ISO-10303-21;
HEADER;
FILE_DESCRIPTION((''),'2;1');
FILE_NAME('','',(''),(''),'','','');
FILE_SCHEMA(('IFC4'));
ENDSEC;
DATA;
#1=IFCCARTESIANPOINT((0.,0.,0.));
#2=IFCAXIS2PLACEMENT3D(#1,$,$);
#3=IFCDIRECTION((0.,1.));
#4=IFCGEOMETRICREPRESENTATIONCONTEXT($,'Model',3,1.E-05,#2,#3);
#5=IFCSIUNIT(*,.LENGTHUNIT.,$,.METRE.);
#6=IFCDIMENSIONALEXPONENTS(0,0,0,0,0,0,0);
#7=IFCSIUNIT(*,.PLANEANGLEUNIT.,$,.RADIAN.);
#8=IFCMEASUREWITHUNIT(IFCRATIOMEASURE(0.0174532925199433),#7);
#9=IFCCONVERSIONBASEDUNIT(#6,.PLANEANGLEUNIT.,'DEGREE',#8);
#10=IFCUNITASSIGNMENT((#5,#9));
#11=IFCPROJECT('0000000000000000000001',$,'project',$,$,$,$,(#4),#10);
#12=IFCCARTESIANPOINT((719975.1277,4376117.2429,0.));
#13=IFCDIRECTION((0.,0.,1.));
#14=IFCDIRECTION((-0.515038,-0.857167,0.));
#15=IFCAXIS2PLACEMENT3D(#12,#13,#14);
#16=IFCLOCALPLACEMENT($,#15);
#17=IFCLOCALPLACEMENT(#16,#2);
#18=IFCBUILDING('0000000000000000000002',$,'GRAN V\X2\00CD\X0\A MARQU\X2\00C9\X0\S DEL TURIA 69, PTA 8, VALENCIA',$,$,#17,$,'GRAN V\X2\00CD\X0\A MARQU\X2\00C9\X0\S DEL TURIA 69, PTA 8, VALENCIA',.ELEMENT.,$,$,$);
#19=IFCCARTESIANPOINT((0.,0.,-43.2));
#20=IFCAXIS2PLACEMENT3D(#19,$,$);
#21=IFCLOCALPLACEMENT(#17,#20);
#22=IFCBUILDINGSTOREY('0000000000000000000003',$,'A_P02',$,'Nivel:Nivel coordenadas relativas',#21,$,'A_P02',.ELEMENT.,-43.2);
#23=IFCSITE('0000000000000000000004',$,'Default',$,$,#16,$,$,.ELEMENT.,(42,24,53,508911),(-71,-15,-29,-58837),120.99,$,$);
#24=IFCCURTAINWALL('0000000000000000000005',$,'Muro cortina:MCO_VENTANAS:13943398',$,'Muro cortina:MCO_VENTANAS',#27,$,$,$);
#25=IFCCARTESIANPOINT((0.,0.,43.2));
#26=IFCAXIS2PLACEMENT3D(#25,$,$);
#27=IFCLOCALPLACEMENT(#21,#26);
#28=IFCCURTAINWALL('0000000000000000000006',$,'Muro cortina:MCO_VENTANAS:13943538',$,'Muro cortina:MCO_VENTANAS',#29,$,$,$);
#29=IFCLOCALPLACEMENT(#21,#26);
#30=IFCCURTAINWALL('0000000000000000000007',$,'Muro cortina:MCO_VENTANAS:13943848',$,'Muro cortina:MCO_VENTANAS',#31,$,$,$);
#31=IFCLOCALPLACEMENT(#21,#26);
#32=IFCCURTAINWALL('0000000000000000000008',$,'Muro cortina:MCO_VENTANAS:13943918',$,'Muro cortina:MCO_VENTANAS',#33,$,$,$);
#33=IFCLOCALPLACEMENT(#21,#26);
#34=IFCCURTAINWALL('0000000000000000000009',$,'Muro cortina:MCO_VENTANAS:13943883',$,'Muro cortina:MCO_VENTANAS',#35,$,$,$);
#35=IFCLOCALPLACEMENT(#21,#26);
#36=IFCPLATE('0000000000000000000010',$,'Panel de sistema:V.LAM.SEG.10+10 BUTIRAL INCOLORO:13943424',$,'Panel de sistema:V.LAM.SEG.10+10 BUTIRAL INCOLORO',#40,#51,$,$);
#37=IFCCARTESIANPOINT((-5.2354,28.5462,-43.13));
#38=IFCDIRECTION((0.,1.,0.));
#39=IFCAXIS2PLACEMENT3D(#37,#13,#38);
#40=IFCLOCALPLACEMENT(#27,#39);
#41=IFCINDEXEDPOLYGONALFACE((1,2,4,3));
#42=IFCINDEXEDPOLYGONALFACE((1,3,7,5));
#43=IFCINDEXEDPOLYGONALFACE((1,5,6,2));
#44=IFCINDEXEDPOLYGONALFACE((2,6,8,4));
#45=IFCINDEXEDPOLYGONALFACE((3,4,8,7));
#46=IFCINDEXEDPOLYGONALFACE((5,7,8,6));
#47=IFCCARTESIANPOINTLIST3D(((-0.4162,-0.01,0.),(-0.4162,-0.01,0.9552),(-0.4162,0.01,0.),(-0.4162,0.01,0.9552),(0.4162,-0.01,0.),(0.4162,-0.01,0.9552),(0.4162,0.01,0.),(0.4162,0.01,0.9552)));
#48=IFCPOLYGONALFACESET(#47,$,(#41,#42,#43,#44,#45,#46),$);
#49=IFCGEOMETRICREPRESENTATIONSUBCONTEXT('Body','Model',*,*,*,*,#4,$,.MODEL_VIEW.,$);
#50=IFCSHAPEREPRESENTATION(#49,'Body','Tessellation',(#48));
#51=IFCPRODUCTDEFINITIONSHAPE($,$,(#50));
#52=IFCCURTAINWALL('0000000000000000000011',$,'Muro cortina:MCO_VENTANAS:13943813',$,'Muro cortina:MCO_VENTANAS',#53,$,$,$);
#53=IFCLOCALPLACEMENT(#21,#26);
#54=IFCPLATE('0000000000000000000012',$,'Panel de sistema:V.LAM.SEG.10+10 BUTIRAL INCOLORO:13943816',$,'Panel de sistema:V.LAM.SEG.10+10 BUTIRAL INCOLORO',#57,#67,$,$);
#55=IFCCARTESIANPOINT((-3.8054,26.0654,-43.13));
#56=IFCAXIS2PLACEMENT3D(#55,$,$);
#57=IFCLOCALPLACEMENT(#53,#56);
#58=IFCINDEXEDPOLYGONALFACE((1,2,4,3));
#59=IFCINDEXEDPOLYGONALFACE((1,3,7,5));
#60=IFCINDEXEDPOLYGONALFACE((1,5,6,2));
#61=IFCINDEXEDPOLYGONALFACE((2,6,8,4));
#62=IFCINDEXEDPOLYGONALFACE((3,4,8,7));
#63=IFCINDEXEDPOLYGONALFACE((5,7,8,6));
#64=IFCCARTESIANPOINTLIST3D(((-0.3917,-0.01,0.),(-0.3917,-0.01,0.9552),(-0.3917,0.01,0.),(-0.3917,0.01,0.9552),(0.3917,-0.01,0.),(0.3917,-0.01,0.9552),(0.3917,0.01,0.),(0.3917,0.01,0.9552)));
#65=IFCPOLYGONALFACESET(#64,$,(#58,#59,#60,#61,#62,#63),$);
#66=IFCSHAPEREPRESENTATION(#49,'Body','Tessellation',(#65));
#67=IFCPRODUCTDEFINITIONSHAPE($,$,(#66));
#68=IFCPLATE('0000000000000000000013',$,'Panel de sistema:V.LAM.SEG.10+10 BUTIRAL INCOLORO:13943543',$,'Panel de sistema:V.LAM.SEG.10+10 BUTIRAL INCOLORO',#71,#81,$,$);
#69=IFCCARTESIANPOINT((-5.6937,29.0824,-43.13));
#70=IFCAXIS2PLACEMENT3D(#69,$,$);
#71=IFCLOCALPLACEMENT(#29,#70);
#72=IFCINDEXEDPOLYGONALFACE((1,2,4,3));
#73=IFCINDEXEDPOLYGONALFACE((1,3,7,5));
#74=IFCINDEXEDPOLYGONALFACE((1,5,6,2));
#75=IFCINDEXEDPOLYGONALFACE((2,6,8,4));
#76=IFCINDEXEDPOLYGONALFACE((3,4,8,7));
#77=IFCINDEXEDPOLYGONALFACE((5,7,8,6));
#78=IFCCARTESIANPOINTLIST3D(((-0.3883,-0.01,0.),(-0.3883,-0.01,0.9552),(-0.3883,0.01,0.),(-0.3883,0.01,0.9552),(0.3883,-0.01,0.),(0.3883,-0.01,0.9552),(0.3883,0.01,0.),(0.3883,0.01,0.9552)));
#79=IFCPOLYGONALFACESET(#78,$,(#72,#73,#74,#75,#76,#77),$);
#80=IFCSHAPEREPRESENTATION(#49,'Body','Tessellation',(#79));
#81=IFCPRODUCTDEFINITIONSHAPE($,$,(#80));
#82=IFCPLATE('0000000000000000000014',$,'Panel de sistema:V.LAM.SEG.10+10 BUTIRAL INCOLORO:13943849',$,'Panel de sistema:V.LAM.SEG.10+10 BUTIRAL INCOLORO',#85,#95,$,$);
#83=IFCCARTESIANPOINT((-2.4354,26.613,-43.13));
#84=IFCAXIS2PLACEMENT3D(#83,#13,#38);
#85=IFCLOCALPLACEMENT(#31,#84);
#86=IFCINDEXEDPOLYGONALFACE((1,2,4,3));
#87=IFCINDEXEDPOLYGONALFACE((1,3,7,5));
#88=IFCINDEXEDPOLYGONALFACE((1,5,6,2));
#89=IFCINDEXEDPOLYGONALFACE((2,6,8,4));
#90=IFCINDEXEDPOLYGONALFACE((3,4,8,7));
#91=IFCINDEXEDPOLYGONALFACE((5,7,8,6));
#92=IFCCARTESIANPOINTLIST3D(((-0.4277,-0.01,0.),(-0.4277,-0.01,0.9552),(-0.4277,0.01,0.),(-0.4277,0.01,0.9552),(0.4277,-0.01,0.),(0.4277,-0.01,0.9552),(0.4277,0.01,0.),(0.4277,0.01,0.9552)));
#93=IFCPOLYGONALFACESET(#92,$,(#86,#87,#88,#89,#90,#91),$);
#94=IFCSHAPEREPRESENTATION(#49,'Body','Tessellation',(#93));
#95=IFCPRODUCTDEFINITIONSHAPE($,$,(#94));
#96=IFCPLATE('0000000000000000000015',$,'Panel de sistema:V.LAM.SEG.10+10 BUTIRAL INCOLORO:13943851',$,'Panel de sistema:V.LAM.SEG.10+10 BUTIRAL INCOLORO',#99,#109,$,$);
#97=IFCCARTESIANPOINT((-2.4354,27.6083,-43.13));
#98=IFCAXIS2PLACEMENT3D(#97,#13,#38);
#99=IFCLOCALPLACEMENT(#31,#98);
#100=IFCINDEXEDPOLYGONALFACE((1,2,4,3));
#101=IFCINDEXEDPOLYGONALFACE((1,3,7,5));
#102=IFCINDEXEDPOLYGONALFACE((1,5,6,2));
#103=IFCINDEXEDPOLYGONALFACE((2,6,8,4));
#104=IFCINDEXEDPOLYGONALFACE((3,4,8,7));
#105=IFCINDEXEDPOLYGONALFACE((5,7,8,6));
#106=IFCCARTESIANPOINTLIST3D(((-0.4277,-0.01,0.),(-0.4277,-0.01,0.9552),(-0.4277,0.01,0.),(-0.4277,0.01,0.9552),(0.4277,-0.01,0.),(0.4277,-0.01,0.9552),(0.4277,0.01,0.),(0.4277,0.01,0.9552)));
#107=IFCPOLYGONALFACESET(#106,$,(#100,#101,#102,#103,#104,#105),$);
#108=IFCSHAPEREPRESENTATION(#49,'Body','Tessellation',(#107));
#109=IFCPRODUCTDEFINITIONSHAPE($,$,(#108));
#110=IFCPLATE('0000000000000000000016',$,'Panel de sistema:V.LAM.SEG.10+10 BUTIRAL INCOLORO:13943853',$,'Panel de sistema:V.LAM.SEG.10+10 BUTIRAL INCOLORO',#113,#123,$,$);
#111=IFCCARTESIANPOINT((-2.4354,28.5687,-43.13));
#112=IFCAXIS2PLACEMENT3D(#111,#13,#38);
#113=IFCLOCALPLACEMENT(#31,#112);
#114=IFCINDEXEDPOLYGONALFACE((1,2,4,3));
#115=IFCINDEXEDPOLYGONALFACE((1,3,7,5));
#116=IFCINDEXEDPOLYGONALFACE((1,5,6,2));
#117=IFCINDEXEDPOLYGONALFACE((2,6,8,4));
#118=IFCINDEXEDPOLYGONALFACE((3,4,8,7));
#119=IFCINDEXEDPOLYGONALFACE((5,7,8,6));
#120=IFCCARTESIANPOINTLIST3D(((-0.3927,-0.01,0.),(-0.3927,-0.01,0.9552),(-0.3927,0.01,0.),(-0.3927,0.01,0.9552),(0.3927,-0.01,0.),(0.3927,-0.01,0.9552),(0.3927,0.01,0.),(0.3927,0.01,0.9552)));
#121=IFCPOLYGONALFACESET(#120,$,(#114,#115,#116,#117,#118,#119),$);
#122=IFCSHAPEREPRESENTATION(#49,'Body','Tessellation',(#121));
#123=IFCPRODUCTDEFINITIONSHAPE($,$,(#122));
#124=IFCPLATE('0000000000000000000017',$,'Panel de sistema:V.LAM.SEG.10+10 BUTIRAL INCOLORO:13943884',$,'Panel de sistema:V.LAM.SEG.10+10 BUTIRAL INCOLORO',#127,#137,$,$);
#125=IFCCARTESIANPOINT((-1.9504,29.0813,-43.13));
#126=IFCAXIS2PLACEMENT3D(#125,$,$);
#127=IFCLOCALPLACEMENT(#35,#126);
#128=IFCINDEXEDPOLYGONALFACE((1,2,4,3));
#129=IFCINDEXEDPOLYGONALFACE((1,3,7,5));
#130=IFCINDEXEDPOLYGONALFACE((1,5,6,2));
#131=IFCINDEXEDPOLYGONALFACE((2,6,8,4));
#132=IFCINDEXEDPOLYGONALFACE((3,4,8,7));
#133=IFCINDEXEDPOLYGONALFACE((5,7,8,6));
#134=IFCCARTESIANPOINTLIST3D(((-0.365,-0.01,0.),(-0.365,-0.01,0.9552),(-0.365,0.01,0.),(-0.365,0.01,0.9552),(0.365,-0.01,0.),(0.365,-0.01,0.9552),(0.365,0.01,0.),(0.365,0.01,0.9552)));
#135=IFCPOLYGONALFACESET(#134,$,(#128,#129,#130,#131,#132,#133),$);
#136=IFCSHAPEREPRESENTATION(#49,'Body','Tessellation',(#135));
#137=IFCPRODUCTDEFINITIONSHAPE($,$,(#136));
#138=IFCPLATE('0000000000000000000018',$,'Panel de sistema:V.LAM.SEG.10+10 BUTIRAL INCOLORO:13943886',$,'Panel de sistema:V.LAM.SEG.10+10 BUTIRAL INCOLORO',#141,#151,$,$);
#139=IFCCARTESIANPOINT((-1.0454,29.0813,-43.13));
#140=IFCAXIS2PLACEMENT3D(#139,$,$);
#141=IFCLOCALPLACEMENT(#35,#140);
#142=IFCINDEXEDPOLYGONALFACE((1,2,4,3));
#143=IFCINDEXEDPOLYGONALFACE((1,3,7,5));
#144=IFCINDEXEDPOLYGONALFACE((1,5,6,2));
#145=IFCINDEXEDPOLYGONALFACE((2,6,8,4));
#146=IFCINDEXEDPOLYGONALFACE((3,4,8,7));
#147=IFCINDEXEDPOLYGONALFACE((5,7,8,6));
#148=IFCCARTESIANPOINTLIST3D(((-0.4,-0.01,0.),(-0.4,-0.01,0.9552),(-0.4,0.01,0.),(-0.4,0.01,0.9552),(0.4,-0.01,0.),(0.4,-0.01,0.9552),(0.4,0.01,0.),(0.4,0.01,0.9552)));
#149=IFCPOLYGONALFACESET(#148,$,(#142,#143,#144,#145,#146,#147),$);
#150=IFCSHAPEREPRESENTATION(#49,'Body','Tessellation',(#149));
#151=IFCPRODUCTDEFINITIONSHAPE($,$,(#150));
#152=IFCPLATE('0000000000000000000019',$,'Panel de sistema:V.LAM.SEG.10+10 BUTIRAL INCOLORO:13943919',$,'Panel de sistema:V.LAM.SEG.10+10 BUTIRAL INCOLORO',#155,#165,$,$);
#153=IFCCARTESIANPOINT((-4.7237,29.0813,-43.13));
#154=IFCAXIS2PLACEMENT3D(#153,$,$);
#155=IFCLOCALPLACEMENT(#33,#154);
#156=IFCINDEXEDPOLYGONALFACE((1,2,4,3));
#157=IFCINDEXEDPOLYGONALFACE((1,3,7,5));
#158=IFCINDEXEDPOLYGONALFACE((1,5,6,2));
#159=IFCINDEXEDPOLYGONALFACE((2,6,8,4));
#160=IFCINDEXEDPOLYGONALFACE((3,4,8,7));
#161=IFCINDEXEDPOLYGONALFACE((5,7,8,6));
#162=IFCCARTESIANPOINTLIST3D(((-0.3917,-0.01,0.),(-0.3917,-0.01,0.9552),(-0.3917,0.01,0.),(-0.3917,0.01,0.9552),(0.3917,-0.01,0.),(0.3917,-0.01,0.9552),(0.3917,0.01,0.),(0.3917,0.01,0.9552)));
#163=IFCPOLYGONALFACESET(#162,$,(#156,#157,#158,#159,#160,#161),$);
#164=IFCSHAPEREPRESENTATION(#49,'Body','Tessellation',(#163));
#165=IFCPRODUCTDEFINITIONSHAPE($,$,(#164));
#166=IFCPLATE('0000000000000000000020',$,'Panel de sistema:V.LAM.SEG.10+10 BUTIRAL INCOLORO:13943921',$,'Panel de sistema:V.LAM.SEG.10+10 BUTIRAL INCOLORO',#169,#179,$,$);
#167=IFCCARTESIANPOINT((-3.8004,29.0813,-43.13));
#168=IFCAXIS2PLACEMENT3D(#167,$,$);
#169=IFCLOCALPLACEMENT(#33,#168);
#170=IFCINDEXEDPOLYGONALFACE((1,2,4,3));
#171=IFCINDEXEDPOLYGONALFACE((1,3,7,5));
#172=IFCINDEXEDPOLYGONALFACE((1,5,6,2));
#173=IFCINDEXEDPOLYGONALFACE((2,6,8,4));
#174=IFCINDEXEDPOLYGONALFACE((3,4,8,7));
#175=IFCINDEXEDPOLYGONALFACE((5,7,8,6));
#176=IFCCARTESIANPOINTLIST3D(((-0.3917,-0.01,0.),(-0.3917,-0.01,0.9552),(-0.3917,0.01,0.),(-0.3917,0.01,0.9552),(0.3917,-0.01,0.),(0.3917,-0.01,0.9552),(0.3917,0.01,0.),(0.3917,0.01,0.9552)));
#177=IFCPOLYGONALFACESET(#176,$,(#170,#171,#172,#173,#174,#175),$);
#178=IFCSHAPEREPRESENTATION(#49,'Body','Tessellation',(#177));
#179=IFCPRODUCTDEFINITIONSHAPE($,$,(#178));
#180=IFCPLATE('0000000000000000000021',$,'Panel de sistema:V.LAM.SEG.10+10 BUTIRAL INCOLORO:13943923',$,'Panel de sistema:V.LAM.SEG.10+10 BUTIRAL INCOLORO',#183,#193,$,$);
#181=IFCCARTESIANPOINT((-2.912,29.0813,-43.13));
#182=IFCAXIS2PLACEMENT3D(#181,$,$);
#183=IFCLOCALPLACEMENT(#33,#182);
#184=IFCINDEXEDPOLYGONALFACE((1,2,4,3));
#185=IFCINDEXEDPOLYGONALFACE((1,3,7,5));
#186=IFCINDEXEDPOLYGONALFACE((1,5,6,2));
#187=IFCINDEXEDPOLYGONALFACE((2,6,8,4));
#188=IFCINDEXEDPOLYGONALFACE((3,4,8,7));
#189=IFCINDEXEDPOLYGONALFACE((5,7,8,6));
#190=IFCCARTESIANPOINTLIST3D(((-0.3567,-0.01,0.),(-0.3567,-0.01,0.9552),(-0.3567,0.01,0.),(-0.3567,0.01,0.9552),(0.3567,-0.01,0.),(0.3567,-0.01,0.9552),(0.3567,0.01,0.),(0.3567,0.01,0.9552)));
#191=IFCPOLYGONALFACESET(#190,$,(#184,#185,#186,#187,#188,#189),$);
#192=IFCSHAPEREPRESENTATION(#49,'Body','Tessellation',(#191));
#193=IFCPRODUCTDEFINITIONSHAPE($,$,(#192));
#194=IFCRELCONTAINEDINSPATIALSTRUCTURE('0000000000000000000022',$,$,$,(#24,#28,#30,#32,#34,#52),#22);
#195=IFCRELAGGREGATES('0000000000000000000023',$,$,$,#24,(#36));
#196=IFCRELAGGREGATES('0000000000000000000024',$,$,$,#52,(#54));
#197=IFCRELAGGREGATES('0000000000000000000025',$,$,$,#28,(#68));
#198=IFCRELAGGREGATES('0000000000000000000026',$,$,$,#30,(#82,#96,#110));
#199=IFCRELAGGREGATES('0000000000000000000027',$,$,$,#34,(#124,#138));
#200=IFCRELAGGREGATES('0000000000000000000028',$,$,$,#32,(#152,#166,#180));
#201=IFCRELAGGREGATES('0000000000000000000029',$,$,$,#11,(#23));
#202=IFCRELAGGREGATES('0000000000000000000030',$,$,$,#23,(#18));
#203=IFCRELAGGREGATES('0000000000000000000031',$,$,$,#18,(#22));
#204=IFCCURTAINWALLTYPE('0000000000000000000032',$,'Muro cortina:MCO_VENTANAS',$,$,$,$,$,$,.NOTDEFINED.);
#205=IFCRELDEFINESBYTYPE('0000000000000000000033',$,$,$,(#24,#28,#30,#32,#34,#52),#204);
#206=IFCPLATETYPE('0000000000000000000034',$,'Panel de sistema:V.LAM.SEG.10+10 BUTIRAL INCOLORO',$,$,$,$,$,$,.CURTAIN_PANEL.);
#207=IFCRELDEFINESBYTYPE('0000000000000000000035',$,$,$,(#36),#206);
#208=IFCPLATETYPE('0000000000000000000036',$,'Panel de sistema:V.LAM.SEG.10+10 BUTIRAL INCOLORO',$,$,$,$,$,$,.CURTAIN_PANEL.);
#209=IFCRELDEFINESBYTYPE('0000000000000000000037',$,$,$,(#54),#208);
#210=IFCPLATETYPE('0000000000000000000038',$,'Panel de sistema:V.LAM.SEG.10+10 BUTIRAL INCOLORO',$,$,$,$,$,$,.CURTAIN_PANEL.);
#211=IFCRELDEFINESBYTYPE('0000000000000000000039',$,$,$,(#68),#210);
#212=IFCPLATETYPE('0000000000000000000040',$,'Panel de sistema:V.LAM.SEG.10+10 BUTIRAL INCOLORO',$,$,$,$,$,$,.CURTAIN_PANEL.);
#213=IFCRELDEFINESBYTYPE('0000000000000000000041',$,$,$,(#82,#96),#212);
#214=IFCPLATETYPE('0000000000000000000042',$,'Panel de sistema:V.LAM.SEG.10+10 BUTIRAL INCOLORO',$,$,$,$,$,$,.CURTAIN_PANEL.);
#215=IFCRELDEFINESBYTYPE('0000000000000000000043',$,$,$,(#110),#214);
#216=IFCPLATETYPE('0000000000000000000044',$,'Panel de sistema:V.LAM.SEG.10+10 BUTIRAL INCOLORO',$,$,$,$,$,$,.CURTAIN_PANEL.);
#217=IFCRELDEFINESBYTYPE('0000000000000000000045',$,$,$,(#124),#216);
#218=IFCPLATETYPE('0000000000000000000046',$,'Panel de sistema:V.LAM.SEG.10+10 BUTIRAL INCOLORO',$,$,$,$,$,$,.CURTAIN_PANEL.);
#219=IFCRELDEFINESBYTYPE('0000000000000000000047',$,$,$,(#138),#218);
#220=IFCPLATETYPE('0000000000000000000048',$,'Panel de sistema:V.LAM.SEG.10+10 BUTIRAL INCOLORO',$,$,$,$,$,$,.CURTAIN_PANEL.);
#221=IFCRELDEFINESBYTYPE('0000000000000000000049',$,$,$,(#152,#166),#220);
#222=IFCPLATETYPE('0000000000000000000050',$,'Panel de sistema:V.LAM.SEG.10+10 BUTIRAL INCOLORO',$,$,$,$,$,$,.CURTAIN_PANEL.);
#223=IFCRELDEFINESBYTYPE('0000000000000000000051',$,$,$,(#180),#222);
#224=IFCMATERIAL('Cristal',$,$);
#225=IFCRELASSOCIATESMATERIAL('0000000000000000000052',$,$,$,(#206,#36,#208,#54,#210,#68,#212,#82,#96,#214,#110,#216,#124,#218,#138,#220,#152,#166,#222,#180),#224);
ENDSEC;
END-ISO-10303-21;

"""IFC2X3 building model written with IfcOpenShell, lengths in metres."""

from ifc_helpers import new_model, entity, si_unit, converted_unit, direction, frame, origin, origin_2d_with_axis, place, context, subcontext, project, spatial, rectangle, extrude, source, transform, mapped, material, type_object, type_shapes, element, aggregate, save


model = new_model("IFC2X3")

# Units and contexts
model_context = context("Model", 3, precision=1e-05, world=origin(), true_north=direction((0.0, 1.0)))
body_context = subcontext(model_context, "Body", "Model", "MODEL_VIEW")
ifc_project = project(units=[si_unit("LENGTHUNIT", "METRE"), converted_unit("PLANEANGLEUNIT", "DEGREE", entity("IfcRatioMeasure", 0.0174532925199433), si_unit("PLANEANGLEUNIT", "RADIAN"), dimensions=[0, 0, 0, 0, 0, 0, 0])], contexts=[model_context])

# Site, building, storey
site_placement = place(None, frame((719975.1277, 4376117.2429, 0.0), z_axis=(0.0, 0.0, 1.0), x_axis=(-0.515038, -0.857167, 0.0)))
site = spatial("IfcSite", under=ifc_project, at=site_placement, Name="Default", CompositionType="ELEMENT", RefLatitude=(42, 24, 53, 508911), RefLongitude=(-71, -15, -29, -58837), RefElevation=120.99)
building_placement = place(site_placement, origin())
building = spatial("IfcBuilding", under=site, at=building_placement, Name="GRAN VÍA MARQUÉS DEL TURIA 69, PTA 8, VALENCIA", LongName="GRAN VÍA MARQUÉS DEL TURIA 69, PTA 8, VALENCIA", CompositionType="ELEMENT")
storey_placement = place(building_placement, frame((0.0, 0.0, -43.2)))
storey = spatial("IfcBuildingStorey", under=building, at=storey_placement, Name="A_P02", ObjectType="Nivel:Nivel coordenadas relativas", LongName="A_P02", CompositionType="ELEMENT", Elevation=-43.2)

# Curtain walls
curtain_wall_type = type_object("IfcCurtainWallType", Name="Muro cortina:MCO_VENTANAS", PredefinedType="NOTDEFINED")
curtain_wall_1_placement = place(storey_placement, frame((0.0, 0.0, 43.2)))
curtain_wall_1 = element("IfcCurtainWall", 1, at=curtain_wall_1_placement, inside=storey, type_object=curtain_wall_type, Name="Muro cortina:MCO_VENTANAS:13943398", ObjectType="Muro cortina:MCO_VENTANAS")
curtain_wall_2_placement = place(storey_placement, frame((0.0, 0.0, 43.2)))
curtain_wall_2 = element("IfcCurtainWall", 2, at=curtain_wall_2_placement, inside=storey, type_object=curtain_wall_type, Name="Muro cortina:MCO_VENTANAS:13943538", ObjectType="Muro cortina:MCO_VENTANAS")
curtain_wall_3_placement = place(storey_placement, frame((0.0, 0.0, 43.2)))
curtain_wall_3 = element("IfcCurtainWall", 3, at=curtain_wall_3_placement, inside=storey, type_object=curtain_wall_type, Name="Muro cortina:MCO_VENTANAS:13943848", ObjectType="Muro cortina:MCO_VENTANAS")
curtain_wall_4_placement = place(storey_placement, frame((0.0, 0.0, 43.2)))
curtain_wall_4 = element("IfcCurtainWall", 4, at=curtain_wall_4_placement, inside=storey, type_object=curtain_wall_type, Name="Muro cortina:MCO_VENTANAS:13943918", ObjectType="Muro cortina:MCO_VENTANAS")

# Curtain wall
curtain_wall_5_placement = place(storey_placement, frame((0.0, 0.0, 43.2)))
curtain_wall_5 = element("IfcCurtainWall", 5, at=curtain_wall_5_placement, inside=storey, type_object=curtain_wall_type, Name="Muro cortina:MCO_VENTANAS:13943883", ObjectType="Muro cortina:MCO_VENTANAS")

# Plate
ifc_material_1 = material(Name="Cristal")
plate_type_1 = type_object("IfcPlateType", Name="Panel de sistema:V.LAM.SEG.10+10 BUTIRAL INCOLORO", PredefinedType="CURTAIN_PANEL", material=ifc_material_1)
shared_shape_1 = source(origin(), body_context, "Body", "SweptSolid", [
    extrude(rectangle(XDim=0.02, YDim=0.8323, at=origin_2d_with_axis()), frame((0.0, 0.0, 0.0), z_axis=(0.0, 0.0, 1.0), x_axis=(0.0, 1.0, 0.0)), (0.0, 0.0, 1.0), 0.9552),
])
type_shapes(plate_type_1, [shared_shape_1])
plate_1_placement = place(curtain_wall_1_placement, frame((-5.2354, 28.5462, -43.13), z_axis=(0.0, 0.0, 1.0), x_axis=(0.0, 1.0, 0.0)))
plate_1 = element("IfcPlate", 6, at=plate_1_placement, type_object=plate_type_1, material=ifc_material_1, Name="Panel de sistema:V.LAM.SEG.10+10 BUTIRAL INCOLORO:13943424", ObjectType="Panel de sistema:V.LAM.SEG.10+10 BUTIRAL INCOLORO", context=body_context, shape_type="MappedRepresentation", body=[
    mapped(shared_shape_1, transform((0.0, 0.0, 0.0), scale=1.0)),
])
aggregate(curtain_wall_1, [plate_1])

# Curtain wall, plate
curtain_wall_6_placement = place(storey_placement, frame((0.0, 0.0, 43.2)))
curtain_wall_6 = element("IfcCurtainWall", 7, at=curtain_wall_6_placement, inside=storey, type_object=curtain_wall_type, Name="Muro cortina:MCO_VENTANAS:13943813", ObjectType="Muro cortina:MCO_VENTANAS")
plate_type_2 = type_object("IfcPlateType", Name="Panel de sistema:V.LAM.SEG.10+10 BUTIRAL INCOLORO", PredefinedType="CURTAIN_PANEL", material=ifc_material_1)
shared_shape_2 = source(origin(), body_context, "Body", "SweptSolid", [
    extrude(rectangle(XDim=0.02, YDim=0.7833, at=origin_2d_with_axis()), frame((0.0, 0.0, 0.0), z_axis=(0.0, 0.0, 1.0), x_axis=(0.0, 1.0, 0.0)), (0.0, 0.0, 1.0), 0.9552),
])
type_shapes(plate_type_2, [shared_shape_2])
plate_2_placement = place(curtain_wall_6_placement, frame((-3.8054, 26.0654, -43.13)))
plate_2 = element("IfcPlate", 8, at=plate_2_placement, type_object=plate_type_2, material=ifc_material_1, Name="Panel de sistema:V.LAM.SEG.10+10 BUTIRAL INCOLORO:13943816", ObjectType="Panel de sistema:V.LAM.SEG.10+10 BUTIRAL INCOLORO", context=body_context, shape_type="MappedRepresentation", body=[
    mapped(shared_shape_2, transform((0.0, 0.0, 0.0), scale=1.0)),
])
aggregate(curtain_wall_6, [plate_2])

# Plates
plate_type_3 = type_object("IfcPlateType", Name="Panel de sistema:V.LAM.SEG.10+10 BUTIRAL INCOLORO", PredefinedType="CURTAIN_PANEL", material=ifc_material_1)
shared_shape_3 = source(origin(), body_context, "Body", "SweptSolid", [
    extrude(rectangle(XDim=0.02, YDim=0.7767, at=origin_2d_with_axis()), frame((0.0, 0.0, 0.0), z_axis=(0.0, 0.0, 1.0), x_axis=(0.0, 1.0, 0.0)), (0.0, 0.0, 1.0), 0.9552),
])
type_shapes(plate_type_3, [shared_shape_3])
plate_3_placement = place(curtain_wall_2_placement, frame((-5.6937, 29.0824, -43.13)))
plate_3 = element("IfcPlate", 9, at=plate_3_placement, type_object=plate_type_3, material=ifc_material_1, Name="Panel de sistema:V.LAM.SEG.10+10 BUTIRAL INCOLORO:13943543", ObjectType="Panel de sistema:V.LAM.SEG.10+10 BUTIRAL INCOLORO", context=body_context, shape_type="MappedRepresentation", body=[
    mapped(shared_shape_3, transform((0.0, 0.0, 0.0), scale=1.0)),
])
aggregate(curtain_wall_2, [plate_3])
plate_type_4 = type_object("IfcPlateType", Name="Panel de sistema:V.LAM.SEG.10+10 BUTIRAL INCOLORO", PredefinedType="CURTAIN_PANEL", material=ifc_material_1)
shared_shape_4 = source(origin(), body_context, "Body", "SweptSolid", [
    extrude(rectangle(XDim=0.02, YDim=0.8553, at=origin_2d_with_axis()), frame((0.0, 0.0, 0.0), z_axis=(0.0, 0.0, 1.0), x_axis=(0.0, 1.0, 0.0)), (0.0, 0.0, 1.0), 0.9552),
])
type_shapes(plate_type_4, [shared_shape_4])
plate_4_placement = place(curtain_wall_3_placement, frame((-2.4354, 26.613, -43.13), z_axis=(0.0, 0.0, 1.0), x_axis=(0.0, 1.0, 0.0)))
plate_4 = element("IfcPlate", 10, at=plate_4_placement, type_object=plate_type_4, material=ifc_material_1, Name="Panel de sistema:V.LAM.SEG.10+10 BUTIRAL INCOLORO:13943849", ObjectType="Panel de sistema:V.LAM.SEG.10+10 BUTIRAL INCOLORO", context=body_context, shape_type="MappedRepresentation", body=[
    mapped(shared_shape_4, transform((0.0, 0.0, 0.0), scale=1.0)),
])
plate_5_placement = place(curtain_wall_3_placement, frame((-2.4354, 27.6083, -43.13), z_axis=(0.0, 0.0, 1.0), x_axis=(0.0, 1.0, 0.0)))
plate_5 = element("IfcPlate", 11, at=plate_5_placement, type_object=plate_type_4, material=ifc_material_1, Name="Panel de sistema:V.LAM.SEG.10+10 BUTIRAL INCOLORO:13943851", ObjectType="Panel de sistema:V.LAM.SEG.10+10 BUTIRAL INCOLORO", context=body_context, shape_type="MappedRepresentation", body=[
    mapped(shared_shape_4, transform((0.0, 0.0, 0.0), scale=1.0)),
])
plate_type_5 = type_object("IfcPlateType", Name="Panel de sistema:V.LAM.SEG.10+10 BUTIRAL INCOLORO", PredefinedType="CURTAIN_PANEL", material=ifc_material_1)
shared_shape_5 = source(origin(), body_context, "Body", "SweptSolid", [
    extrude(rectangle(XDim=0.02, YDim=0.7853, at=origin_2d_with_axis()), frame((0.0, 0.0, 0.0), z_axis=(0.0, 0.0, 1.0), x_axis=(0.0, 1.0, 0.0)), (0.0, 0.0, 1.0), 0.9552),
])
type_shapes(plate_type_5, [shared_shape_5])
plate_6_placement = place(curtain_wall_3_placement, frame((-2.4354, 28.5687, -43.13), z_axis=(0.0, 0.0, 1.0), x_axis=(0.0, 1.0, 0.0)))
plate_6 = element("IfcPlate", 12, at=plate_6_placement, type_object=plate_type_5, material=ifc_material_1, Name="Panel de sistema:V.LAM.SEG.10+10 BUTIRAL INCOLORO:13943853", ObjectType="Panel de sistema:V.LAM.SEG.10+10 BUTIRAL INCOLORO", context=body_context, shape_type="MappedRepresentation", body=[
    mapped(shared_shape_5, transform((0.0, 0.0, 0.0), scale=1.0)),
])
aggregate(curtain_wall_3, [plate_4, plate_5, plate_6])
plate_type_6 = type_object("IfcPlateType", Name="Panel de sistema:V.LAM.SEG.10+10 BUTIRAL INCOLORO", PredefinedType="CURTAIN_PANEL", material=ifc_material_1)
shared_shape_6 = source(origin(), body_context, "Body", "SweptSolid", [
    extrude(rectangle(XDim=0.02, YDim=0.73, at=origin_2d_with_axis()), frame((0.0, 0.0, 0.0), z_axis=(0.0, 0.0, 1.0), x_axis=(0.0, 1.0, 0.0)), (0.0, 0.0, 1.0), 0.9552),
])
type_shapes(plate_type_6, [shared_shape_6])
plate_7_placement = place(curtain_wall_5_placement, frame((-1.9504, 29.0813, -43.13)))
plate_7 = element("IfcPlate", 13, at=plate_7_placement, type_object=plate_type_6, material=ifc_material_1, Name="Panel de sistema:V.LAM.SEG.10+10 BUTIRAL INCOLORO:13943884", ObjectType="Panel de sistema:V.LAM.SEG.10+10 BUTIRAL INCOLORO", context=body_context, shape_type="MappedRepresentation", body=[
    mapped(shared_shape_6, transform((0.0, 0.0, 0.0), scale=1.0)),
])
plate_type_7 = type_object("IfcPlateType", Name="Panel de sistema:V.LAM.SEG.10+10 BUTIRAL INCOLORO", PredefinedType="CURTAIN_PANEL", material=ifc_material_1)
shared_shape_7 = source(origin(), body_context, "Body", "SweptSolid", [
    extrude(rectangle(XDim=0.02, YDim=0.8, at=origin_2d_with_axis()), frame((0.0, 0.0, 0.0), z_axis=(0.0, 0.0, 1.0), x_axis=(0.0, 1.0, 0.0)), (0.0, 0.0, 1.0), 0.9552),
])
type_shapes(plate_type_7, [shared_shape_7])
plate_8_placement = place(curtain_wall_5_placement, frame((-1.0454, 29.0813, -43.13)))
plate_8 = element("IfcPlate", 14, at=plate_8_placement, type_object=plate_type_7, material=ifc_material_1, Name="Panel de sistema:V.LAM.SEG.10+10 BUTIRAL INCOLORO:13943886", ObjectType="Panel de sistema:V.LAM.SEG.10+10 BUTIRAL INCOLORO", context=body_context, shape_type="MappedRepresentation", body=[
    mapped(shared_shape_7, transform((0.0, 0.0, 0.0), scale=1.0)),
])
aggregate(curtain_wall_5, [plate_7, plate_8])
plate_type_8 = type_object("IfcPlateType", Name="Panel de sistema:V.LAM.SEG.10+10 BUTIRAL INCOLORO", PredefinedType="CURTAIN_PANEL", material=ifc_material_1)
shared_shape_8 = source(origin(), body_context, "Body", "SweptSolid", [
    extrude(rectangle(XDim=0.02, YDim=0.7833, at=origin_2d_with_axis()), frame((0.0, 0.0, 0.0), z_axis=(0.0, 0.0, 1.0), x_axis=(0.0, 1.0, 0.0)), (0.0, 0.0, 1.0), 0.9552),
])
type_shapes(plate_type_8, [shared_shape_8])
plate_9_placement = place(curtain_wall_4_placement, frame((-4.7237, 29.0813, -43.13)))
plate_9 = element("IfcPlate", 15, at=plate_9_placement, type_object=plate_type_8, material=ifc_material_1, Name="Panel de sistema:V.LAM.SEG.10+10 BUTIRAL INCOLORO:13943919", ObjectType="Panel de sistema:V.LAM.SEG.10+10 BUTIRAL INCOLORO", context=body_context, shape_type="MappedRepresentation", body=[
    mapped(shared_shape_8, transform((0.0, 0.0, 0.0), scale=1.0)),
])
plate_10_placement = place(curtain_wall_4_placement, frame((-3.8004, 29.0813, -43.13)))
plate_10 = element("IfcPlate", 16, at=plate_10_placement, type_object=plate_type_8, material=ifc_material_1, Name="Panel de sistema:V.LAM.SEG.10+10 BUTIRAL INCOLORO:13943921", ObjectType="Panel de sistema:V.LAM.SEG.10+10 BUTIRAL INCOLORO", context=body_context, shape_type="MappedRepresentation", body=[
    mapped(shared_shape_8, transform((0.0, 0.0, 0.0), scale=1.0)),
])
plate_type_9 = type_object("IfcPlateType", Name="Panel de sistema:V.LAM.SEG.10+10 BUTIRAL INCOLORO", PredefinedType="CURTAIN_PANEL", material=ifc_material_1)
shared_shape_9 = source(origin(), body_context, "Body", "SweptSolid", [
    extrude(rectangle(XDim=0.02, YDim=0.7133, at=origin_2d_with_axis()), frame((0.0, 0.0, 0.0), z_axis=(0.0, 0.0, 1.0), x_axis=(0.0, 1.0, 0.0)), (0.0, 0.0, 1.0), 0.9552),
])
type_shapes(plate_type_9, [shared_shape_9])
plate_11_placement = place(curtain_wall_4_placement, frame((-2.912, 29.0813, -43.13)))
plate_11 = element("IfcPlate", 17, at=plate_11_placement, type_object=plate_type_9, material=ifc_material_1, Name="Panel de sistema:V.LAM.SEG.10+10 BUTIRAL INCOLORO:13943923", ObjectType="Panel de sistema:V.LAM.SEG.10+10 BUTIRAL INCOLORO", context=body_context, shape_type="MappedRepresentation", body=[
    mapped(shared_shape_9, transform((0.0, 0.0, 0.0), scale=1.0)),
])
aggregate(curtain_wall_4, [plate_9, plate_10, plate_11])

save(model, "model.ifc")
